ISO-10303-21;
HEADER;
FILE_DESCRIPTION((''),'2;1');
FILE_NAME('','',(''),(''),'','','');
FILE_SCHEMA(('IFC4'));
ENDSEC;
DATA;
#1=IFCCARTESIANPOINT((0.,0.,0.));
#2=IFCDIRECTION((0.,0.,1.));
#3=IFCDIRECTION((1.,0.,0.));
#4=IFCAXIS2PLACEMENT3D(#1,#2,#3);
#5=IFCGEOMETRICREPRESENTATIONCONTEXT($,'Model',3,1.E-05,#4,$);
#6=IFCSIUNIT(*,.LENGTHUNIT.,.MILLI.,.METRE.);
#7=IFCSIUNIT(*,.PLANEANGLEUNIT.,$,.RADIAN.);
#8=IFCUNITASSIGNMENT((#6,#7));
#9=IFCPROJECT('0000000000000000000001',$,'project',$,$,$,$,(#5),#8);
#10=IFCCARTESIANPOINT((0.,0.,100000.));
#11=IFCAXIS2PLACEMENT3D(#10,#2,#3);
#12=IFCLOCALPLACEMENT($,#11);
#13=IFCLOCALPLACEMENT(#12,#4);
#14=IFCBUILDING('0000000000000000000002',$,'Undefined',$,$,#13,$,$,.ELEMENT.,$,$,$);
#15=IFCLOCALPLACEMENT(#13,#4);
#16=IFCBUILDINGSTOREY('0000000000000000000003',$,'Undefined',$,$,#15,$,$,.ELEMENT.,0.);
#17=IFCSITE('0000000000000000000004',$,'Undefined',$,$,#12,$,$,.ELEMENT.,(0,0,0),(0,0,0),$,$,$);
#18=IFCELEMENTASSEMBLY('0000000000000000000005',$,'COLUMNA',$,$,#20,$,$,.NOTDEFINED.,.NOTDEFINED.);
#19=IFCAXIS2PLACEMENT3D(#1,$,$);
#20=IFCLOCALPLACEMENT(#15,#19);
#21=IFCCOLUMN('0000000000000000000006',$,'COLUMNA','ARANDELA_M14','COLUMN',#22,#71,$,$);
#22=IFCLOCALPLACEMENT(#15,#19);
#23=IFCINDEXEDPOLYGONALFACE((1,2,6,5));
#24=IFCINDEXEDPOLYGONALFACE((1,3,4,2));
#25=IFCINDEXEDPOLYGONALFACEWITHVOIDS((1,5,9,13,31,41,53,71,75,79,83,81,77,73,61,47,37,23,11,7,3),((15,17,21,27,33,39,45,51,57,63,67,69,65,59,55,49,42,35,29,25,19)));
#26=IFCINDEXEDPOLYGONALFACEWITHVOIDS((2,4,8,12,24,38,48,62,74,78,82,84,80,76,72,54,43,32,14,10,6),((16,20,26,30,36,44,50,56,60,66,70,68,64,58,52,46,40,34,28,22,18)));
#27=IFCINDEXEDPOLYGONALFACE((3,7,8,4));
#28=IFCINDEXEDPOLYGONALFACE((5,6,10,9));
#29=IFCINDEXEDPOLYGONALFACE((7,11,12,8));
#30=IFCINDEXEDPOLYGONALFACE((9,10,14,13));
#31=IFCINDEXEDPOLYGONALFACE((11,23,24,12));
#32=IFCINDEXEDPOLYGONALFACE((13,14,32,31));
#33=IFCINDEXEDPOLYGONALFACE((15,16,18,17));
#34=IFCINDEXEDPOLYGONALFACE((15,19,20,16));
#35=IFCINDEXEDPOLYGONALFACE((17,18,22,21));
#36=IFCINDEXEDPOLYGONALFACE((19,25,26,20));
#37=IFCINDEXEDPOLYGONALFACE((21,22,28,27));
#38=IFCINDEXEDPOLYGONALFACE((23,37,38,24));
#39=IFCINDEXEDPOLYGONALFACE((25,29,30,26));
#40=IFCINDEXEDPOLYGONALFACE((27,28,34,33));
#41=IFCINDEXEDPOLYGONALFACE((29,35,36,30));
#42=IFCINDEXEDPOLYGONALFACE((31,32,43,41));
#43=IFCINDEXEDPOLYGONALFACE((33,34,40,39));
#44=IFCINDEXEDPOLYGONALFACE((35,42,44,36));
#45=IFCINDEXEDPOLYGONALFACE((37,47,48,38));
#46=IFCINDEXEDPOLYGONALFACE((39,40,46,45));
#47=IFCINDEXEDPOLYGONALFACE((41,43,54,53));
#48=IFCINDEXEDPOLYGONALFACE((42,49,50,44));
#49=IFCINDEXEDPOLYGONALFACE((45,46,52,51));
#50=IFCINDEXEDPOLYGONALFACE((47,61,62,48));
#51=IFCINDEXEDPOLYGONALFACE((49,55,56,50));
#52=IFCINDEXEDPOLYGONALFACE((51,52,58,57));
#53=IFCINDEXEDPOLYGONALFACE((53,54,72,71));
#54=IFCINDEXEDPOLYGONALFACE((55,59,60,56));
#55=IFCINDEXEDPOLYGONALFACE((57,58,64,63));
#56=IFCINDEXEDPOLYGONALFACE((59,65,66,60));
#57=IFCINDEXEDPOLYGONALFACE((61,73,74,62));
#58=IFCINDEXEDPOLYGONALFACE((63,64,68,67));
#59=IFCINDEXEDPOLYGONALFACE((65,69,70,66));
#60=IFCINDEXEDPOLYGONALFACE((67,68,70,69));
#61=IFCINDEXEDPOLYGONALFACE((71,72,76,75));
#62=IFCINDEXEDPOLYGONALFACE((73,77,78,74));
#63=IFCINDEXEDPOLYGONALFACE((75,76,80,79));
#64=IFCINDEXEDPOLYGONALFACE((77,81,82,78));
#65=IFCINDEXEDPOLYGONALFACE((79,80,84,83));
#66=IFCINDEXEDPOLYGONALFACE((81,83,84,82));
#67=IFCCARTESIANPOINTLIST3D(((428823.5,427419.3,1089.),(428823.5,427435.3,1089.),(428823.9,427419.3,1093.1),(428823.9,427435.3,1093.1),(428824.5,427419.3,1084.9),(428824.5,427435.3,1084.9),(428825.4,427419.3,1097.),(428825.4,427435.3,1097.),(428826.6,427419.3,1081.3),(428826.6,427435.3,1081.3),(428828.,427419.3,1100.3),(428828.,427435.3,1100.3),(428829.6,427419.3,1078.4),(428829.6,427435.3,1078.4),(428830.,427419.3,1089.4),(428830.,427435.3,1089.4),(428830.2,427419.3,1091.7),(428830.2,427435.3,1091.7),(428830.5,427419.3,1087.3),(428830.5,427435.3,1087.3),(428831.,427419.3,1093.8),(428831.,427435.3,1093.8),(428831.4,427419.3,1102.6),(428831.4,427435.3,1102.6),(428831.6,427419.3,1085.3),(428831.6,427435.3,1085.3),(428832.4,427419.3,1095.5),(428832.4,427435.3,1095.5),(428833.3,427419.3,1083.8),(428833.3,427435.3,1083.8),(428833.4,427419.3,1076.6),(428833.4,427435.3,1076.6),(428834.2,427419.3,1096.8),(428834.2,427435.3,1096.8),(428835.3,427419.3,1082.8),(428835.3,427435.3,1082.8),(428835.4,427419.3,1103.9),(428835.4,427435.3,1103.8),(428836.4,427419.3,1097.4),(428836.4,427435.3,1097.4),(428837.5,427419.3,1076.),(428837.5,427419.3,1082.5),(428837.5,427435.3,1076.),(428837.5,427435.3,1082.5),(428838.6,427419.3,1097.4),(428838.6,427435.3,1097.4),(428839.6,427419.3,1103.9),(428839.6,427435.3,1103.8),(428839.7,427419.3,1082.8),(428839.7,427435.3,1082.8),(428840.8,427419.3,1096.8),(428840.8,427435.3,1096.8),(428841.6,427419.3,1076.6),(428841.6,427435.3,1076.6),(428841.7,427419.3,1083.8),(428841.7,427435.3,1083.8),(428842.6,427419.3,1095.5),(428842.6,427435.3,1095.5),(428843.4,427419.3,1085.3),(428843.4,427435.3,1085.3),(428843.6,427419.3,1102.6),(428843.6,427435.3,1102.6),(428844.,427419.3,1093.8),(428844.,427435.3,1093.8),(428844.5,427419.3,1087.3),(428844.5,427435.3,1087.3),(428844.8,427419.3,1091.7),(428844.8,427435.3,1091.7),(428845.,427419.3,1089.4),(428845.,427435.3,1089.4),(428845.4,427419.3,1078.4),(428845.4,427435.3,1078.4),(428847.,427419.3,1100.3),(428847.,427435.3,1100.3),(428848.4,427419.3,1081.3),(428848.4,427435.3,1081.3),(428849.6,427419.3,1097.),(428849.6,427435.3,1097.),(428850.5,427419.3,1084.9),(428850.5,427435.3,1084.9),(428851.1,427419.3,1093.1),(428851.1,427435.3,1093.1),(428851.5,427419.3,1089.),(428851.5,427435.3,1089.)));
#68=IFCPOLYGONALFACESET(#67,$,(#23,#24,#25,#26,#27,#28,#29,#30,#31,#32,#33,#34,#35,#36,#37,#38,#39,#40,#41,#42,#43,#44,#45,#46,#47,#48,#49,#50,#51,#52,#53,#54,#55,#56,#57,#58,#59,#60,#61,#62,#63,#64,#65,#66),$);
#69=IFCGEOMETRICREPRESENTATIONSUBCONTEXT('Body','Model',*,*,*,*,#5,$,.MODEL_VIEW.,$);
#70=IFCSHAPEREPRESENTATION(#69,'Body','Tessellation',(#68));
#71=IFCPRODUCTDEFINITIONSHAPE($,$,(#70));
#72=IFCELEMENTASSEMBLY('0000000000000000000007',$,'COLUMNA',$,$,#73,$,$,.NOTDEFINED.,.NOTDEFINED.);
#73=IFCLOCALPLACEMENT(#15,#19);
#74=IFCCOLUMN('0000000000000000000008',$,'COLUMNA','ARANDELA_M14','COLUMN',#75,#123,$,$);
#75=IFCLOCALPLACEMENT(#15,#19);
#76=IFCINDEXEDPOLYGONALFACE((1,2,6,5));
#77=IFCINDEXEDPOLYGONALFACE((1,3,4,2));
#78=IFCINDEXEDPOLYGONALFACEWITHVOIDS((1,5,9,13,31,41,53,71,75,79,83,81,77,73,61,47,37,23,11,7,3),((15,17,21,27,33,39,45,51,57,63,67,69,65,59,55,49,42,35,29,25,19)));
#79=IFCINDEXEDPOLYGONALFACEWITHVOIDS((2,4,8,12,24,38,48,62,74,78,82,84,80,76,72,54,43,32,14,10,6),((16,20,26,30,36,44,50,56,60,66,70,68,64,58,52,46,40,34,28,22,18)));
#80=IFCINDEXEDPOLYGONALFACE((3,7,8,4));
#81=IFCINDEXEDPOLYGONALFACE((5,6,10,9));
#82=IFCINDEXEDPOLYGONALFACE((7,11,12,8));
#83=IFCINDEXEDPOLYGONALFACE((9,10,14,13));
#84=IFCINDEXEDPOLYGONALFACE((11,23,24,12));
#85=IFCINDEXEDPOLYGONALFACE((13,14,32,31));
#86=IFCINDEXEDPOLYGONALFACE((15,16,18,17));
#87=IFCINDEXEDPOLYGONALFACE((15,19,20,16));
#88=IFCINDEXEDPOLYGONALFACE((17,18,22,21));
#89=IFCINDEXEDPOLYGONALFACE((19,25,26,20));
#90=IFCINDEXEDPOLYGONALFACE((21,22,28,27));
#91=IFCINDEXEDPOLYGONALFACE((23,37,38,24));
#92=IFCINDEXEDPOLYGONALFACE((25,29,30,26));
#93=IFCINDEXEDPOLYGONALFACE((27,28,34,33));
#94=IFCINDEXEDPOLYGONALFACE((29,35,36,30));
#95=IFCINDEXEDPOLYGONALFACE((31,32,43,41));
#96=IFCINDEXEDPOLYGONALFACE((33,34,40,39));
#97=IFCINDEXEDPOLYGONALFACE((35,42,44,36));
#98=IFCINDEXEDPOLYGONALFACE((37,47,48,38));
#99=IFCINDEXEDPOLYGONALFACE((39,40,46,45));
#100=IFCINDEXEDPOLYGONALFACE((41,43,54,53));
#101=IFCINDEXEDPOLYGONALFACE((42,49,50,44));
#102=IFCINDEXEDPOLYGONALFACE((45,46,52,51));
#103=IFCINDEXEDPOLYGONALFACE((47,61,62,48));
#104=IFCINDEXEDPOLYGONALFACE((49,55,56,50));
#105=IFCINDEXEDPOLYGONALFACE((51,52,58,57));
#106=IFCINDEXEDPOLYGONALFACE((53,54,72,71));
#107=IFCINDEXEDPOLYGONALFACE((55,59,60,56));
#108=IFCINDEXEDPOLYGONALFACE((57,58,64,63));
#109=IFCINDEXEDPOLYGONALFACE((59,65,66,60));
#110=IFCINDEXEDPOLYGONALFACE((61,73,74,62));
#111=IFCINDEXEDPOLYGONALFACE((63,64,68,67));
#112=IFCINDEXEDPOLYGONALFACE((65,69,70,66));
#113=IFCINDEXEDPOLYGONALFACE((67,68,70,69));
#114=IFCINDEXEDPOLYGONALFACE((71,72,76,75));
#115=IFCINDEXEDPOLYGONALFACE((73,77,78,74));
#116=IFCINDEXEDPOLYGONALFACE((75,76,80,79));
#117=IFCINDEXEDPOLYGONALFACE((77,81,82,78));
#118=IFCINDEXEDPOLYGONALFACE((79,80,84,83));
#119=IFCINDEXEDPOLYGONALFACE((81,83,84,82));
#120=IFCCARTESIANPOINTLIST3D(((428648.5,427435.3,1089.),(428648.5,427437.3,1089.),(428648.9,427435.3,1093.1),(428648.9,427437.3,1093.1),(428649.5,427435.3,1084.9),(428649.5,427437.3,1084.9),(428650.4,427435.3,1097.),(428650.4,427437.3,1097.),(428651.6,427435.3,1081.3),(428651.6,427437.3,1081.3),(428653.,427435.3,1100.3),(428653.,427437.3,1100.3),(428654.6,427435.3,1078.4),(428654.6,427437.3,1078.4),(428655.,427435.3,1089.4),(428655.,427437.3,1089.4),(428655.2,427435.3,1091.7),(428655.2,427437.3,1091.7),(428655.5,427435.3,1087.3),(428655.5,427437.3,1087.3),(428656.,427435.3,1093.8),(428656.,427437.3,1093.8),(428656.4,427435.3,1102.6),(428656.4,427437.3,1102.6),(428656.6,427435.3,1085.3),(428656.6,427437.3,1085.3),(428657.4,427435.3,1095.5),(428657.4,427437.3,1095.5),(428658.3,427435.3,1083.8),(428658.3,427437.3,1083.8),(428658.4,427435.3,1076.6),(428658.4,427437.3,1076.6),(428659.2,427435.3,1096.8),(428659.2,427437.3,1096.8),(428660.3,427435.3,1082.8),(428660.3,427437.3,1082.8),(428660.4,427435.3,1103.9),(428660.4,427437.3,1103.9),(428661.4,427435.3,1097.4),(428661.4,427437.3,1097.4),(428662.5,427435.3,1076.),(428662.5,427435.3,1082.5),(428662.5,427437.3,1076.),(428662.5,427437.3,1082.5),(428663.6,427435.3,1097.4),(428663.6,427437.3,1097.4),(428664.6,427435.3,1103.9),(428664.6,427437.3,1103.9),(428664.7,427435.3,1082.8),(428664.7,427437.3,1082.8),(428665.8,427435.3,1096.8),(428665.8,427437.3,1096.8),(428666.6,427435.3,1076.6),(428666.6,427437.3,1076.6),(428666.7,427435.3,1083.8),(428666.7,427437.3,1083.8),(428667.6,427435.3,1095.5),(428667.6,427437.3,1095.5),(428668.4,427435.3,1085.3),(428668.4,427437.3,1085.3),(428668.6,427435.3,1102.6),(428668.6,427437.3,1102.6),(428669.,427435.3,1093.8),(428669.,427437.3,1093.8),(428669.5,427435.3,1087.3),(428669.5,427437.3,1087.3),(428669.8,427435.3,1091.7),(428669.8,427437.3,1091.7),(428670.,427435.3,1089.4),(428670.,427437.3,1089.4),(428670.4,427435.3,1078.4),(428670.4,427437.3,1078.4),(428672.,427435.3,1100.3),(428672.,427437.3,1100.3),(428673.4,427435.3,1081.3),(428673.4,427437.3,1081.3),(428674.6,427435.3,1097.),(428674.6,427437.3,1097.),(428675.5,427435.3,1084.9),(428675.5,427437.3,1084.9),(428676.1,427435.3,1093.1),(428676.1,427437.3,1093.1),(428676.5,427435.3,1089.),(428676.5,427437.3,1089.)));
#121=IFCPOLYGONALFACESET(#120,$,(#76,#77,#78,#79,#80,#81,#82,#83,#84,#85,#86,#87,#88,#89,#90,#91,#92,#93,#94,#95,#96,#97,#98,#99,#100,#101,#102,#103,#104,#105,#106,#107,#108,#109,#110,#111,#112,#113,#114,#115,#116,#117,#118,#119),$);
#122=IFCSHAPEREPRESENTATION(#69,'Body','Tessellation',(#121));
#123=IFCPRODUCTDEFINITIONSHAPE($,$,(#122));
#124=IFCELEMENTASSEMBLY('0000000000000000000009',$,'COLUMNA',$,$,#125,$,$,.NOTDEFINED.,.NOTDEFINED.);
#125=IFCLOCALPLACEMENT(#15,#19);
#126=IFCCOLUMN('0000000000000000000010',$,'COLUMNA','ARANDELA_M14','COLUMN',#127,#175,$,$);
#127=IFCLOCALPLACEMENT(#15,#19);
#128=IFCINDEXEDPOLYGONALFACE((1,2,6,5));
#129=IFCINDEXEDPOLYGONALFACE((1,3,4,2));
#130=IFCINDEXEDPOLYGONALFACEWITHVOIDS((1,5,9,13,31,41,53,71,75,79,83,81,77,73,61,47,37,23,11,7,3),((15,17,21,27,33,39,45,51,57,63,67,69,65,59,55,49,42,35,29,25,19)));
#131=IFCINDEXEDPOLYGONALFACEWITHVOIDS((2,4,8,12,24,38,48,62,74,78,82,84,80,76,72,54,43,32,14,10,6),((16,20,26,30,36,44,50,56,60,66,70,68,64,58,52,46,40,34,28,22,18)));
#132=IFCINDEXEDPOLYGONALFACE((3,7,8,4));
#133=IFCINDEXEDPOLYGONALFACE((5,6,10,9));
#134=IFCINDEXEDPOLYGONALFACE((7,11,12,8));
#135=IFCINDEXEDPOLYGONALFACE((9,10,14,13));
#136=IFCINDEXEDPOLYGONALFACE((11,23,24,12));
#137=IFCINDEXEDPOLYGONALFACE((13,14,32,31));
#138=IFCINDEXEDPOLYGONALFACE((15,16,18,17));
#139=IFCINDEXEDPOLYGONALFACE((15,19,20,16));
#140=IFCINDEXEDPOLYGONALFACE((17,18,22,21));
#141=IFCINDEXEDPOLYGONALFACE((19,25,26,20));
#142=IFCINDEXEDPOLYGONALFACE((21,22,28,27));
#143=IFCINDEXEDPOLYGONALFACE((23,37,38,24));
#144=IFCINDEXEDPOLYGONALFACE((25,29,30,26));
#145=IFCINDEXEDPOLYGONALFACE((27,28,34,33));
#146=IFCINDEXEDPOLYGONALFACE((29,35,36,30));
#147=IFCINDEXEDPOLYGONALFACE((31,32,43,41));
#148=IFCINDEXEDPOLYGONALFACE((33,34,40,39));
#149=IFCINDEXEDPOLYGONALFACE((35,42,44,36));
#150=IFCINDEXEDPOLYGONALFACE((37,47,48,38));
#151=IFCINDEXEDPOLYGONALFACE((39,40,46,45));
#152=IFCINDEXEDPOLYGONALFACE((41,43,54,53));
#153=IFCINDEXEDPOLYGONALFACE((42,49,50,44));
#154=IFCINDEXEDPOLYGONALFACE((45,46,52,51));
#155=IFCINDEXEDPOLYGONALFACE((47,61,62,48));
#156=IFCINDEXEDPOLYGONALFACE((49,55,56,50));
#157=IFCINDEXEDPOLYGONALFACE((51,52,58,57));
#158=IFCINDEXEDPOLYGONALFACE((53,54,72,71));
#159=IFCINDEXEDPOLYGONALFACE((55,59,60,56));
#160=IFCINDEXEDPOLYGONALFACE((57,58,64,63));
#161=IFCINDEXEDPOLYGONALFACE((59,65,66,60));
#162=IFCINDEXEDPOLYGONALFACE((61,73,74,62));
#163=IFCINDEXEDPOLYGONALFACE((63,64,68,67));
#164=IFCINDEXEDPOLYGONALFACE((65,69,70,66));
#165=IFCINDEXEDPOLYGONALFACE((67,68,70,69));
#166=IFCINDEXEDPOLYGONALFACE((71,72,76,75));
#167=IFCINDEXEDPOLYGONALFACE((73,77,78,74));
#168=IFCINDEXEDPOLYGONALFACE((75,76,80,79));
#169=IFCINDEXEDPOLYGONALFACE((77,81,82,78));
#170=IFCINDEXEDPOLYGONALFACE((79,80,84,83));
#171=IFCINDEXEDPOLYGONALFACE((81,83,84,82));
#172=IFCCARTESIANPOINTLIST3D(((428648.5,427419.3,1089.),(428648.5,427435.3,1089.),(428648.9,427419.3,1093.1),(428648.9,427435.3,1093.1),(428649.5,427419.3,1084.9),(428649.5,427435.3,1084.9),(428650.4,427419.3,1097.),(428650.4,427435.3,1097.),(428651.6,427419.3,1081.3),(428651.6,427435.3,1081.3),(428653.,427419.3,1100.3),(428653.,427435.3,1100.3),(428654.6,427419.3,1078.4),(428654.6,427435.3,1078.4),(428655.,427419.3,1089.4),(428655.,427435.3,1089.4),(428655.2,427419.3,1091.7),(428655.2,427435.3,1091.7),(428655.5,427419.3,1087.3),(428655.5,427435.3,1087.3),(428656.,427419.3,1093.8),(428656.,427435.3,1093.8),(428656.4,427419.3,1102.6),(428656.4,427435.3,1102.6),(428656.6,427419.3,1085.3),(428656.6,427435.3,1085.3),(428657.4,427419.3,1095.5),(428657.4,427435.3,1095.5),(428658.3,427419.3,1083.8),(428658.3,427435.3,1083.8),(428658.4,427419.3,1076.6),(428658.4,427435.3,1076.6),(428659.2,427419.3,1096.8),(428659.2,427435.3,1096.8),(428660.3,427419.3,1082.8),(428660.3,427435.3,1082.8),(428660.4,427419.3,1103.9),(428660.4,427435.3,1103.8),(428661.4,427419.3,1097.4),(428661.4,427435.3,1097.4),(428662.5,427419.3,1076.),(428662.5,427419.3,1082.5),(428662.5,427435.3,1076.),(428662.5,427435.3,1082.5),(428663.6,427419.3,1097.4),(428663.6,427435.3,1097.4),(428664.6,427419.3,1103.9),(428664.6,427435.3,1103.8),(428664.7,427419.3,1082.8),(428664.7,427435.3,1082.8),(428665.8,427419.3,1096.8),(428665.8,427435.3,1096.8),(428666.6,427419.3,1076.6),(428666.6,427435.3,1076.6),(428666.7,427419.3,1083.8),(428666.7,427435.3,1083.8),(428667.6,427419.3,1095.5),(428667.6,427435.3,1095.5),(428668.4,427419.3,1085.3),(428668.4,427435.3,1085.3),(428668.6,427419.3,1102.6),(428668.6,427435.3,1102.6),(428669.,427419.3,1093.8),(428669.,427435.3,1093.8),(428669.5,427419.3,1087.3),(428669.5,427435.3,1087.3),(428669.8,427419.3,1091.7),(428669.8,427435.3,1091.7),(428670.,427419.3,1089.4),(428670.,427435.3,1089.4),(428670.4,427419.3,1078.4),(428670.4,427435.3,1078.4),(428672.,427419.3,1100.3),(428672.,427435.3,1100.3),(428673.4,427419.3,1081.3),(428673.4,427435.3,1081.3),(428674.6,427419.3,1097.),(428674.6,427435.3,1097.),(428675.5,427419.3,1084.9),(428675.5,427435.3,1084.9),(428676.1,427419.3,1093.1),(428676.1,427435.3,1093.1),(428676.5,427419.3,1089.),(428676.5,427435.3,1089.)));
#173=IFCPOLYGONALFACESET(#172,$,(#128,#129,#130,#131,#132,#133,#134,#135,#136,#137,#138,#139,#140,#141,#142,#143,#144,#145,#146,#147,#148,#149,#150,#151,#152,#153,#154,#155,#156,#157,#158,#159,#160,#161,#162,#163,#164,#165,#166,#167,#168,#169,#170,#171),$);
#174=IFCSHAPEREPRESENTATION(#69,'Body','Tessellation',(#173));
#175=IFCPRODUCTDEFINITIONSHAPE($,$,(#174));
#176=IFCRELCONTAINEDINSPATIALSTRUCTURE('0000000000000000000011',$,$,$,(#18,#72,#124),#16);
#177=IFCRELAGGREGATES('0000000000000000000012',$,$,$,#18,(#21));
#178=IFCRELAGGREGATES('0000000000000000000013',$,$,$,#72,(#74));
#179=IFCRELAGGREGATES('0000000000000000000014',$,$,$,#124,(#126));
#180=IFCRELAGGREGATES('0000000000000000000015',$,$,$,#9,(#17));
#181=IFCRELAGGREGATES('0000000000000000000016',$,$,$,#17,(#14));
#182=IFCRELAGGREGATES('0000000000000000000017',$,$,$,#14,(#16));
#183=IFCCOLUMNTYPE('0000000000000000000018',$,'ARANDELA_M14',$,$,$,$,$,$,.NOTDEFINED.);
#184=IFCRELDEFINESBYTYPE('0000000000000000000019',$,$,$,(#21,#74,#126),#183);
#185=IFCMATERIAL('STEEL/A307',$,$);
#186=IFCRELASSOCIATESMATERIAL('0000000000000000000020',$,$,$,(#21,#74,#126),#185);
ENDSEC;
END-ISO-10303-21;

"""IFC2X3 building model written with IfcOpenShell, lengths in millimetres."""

from ifc_helpers import new_model, si_unit, frame, origin_with_axes, origin_2d_with_axis, place, context, subcontext, project, spatial, hollow_circle, extrude, material, type_object, element, aggregate, save


model = new_model("IFC2X3")

# Units and contexts
model_context = context("Model", 3, precision=1e-05, world=origin_with_axes())
body_context = subcontext(model_context, "Body", "Model", "MODEL_VIEW")
ifc_project = project(units=[si_unit("LENGTHUNIT", "METRE", prefix="MILLI"), si_unit("PLANEANGLEUNIT", "RADIAN")], contexts=[model_context])

# Site, building, storey
site_placement = place(None, frame((0.0, 0.0, 100000.0), z_axis=(0.0, 0.0, 1.0), x_axis=(1.0, 0.0, 0.0)))
site = spatial("IfcSite", under=ifc_project, at=site_placement, Name="Undefined", CompositionType="ELEMENT", RefLatitude=(0, 0, 0), RefLongitude=(0, 0, 0))
building_placement = place(site_placement, origin_with_axes())
building = spatial("IfcBuilding", under=site, at=building_placement, Name="Undefined", CompositionType="ELEMENT")
storey_placement = place(building_placement, origin_with_axes())
storey = spatial("IfcBuildingStorey", under=building, at=storey_placement, Name="Undefined", CompositionType="ELEMENT", Elevation=0.0)

# Element assemblies, columns
ifc_material_1 = material(Name="STEEL/A307")
column_type_1 = type_object("IfcColumnType", Name="ARANDELA_M14", PredefinedType="NOTDEFINED")
assembly_1_placement = place(storey_placement, origin_with_axes())
assembly_1 = element("IfcElementAssembly", 1, at=assembly_1_placement, inside=storey, Name="COLUMNA", AssemblyPlace="NOTDEFINED", PredefinedType="NOTDEFINED")
column_1_placement = place(assembly_1_placement, frame((428837.5, 427435.3, 1090.0), z_axis=(0.0, -1.0, 0.000285), x_axis=(-1.0, 0.0, 0.0)))
column_1 = element("IfcColumn", 2, at=column_1_placement, type_object=column_type_1, material=ifc_material_1, Name="COLUMNA", Description="ARANDELA_M14", ObjectType="COLUMN", context=body_context, shape_type="SweptSolid", body=[
    extrude(hollow_circle(Radius=14.0, WallThickness=6.5, at=origin_2d_with_axis()), frame((0.0, 0.0, 16.0), z_axis=(0.0, 0.0, -1.0), x_axis=(0.0, 1.0, 0.0)), (0.0, 0.0, 1.0), 16.0),
])
aggregate(assembly_1, [column_1])
assembly_2_placement = place(storey_placement, origin_with_axes())
assembly_2 = element("IfcElementAssembly", 3, at=assembly_2_placement, inside=storey, Name="COLUMNA", AssemblyPlace="NOTDEFINED", PredefinedType="NOTDEFINED")
column_2_placement = place(assembly_2_placement, frame((428662.5, 427437.3, 1090.0), z_axis=(0.0, -1.0, 0.000285), x_axis=(-1.0, 0.0, 0.0)))
column_2 = element("IfcColumn", 4, at=column_2_placement, type_object=column_type_1, material=ifc_material_1, Name="COLUMNA", Description="ARANDELA_M14", ObjectType="COLUMN", context=body_context, shape_type="SweptSolid", body=[
    extrude(hollow_circle(Radius=14.0, WallThickness=6.5, at=origin_2d_with_axis()), frame((0.0, 0.0, 2.0), z_axis=(0.0, 0.0, -1.0), x_axis=(0.0, 1.0, 0.0)), (0.0, 0.0, 1.0), 2.0),
])
aggregate(assembly_2, [column_2])
assembly_3_placement = place(storey_placement, origin_with_axes())
assembly_3 = element("IfcElementAssembly", 5, at=assembly_3_placement, inside=storey, Name="COLUMNA", AssemblyPlace="NOTDEFINED", PredefinedType="NOTDEFINED")
column_3_placement = place(assembly_3_placement, frame((428662.5, 427435.3, 1090.0), z_axis=(0.0, -1.0, 0.000285), x_axis=(-1.0, 0.0, 0.0)))
column_3 = element("IfcColumn", 6, at=column_3_placement, type_object=column_type_1, material=ifc_material_1, Name="COLUMNA", Description="ARANDELA_M14", ObjectType="COLUMN", context=body_context, shape_type="SweptSolid", body=[
    extrude(hollow_circle(Radius=14.0, WallThickness=6.5, at=origin_2d_with_axis()), frame((0.0, 0.0, 16.0), z_axis=(0.0, 0.0, -1.0), x_axis=(0.0, 1.0, 0.0)), (0.0, 0.0, 1.0), 16.0),
])
aggregate(assembly_3, [column_3])

save(model, "model.ifc")
